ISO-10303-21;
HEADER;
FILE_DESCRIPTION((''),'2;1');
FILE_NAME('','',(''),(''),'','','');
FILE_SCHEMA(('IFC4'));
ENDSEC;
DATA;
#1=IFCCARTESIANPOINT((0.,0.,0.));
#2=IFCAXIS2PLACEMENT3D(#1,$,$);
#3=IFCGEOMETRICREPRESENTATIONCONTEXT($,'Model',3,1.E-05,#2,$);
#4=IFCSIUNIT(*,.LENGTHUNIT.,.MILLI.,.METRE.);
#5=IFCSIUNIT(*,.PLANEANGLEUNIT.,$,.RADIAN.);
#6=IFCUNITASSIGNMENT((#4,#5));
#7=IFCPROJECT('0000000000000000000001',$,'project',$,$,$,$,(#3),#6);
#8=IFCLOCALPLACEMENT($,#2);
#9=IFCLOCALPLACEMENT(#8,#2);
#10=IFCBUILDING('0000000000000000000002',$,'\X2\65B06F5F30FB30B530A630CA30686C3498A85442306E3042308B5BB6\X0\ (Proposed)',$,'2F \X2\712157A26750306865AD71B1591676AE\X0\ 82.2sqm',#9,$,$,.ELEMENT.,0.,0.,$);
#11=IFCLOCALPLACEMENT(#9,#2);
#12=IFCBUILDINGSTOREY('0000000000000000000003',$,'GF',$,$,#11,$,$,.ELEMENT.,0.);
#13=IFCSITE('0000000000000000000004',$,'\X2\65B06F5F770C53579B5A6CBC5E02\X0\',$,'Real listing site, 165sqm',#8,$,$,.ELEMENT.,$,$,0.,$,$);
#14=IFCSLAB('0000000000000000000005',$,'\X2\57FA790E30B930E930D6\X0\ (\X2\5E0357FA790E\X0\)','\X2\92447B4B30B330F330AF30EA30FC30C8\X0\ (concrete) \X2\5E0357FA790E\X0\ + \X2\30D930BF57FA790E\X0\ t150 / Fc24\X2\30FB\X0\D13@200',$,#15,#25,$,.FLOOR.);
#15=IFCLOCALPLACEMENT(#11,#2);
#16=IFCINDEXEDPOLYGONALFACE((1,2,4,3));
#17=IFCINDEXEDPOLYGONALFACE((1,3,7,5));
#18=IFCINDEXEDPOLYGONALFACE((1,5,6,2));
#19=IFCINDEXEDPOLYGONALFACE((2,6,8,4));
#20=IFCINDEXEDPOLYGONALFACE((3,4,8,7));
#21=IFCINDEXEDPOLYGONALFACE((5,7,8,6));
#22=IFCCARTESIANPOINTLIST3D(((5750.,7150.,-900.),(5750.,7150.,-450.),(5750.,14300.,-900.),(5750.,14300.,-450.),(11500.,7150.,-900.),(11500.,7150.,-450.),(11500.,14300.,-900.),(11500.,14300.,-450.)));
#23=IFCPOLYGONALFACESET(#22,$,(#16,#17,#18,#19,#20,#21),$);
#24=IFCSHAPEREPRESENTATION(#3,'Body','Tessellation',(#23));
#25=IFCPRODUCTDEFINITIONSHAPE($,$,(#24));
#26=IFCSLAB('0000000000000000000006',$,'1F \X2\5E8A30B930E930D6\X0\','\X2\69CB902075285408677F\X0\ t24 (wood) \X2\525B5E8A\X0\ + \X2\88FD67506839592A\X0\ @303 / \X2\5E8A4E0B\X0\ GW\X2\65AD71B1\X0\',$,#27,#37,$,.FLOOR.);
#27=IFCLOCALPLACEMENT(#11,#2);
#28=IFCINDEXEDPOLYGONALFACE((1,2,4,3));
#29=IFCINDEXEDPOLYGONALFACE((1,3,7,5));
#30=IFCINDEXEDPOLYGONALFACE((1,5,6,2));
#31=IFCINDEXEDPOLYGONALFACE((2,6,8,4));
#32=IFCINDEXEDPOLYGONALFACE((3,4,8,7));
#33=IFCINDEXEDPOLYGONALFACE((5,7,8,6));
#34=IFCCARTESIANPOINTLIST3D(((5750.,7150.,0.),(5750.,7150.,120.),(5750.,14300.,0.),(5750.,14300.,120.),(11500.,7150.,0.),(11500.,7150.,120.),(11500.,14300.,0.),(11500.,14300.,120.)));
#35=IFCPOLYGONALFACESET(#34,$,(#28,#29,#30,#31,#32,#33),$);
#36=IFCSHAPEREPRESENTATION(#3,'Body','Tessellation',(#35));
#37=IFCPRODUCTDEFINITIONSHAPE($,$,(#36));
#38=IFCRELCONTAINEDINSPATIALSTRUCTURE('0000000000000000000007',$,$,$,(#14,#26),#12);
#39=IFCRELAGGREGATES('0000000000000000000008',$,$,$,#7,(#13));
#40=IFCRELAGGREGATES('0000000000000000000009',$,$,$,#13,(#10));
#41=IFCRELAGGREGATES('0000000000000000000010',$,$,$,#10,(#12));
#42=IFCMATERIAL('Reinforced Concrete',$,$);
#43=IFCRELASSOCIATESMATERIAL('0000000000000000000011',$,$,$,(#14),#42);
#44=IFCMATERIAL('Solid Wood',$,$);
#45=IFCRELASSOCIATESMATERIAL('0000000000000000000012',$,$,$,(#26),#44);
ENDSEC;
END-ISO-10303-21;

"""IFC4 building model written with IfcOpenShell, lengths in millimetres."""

from ifc_helpers import new_model, si_unit, frame, frame_2d, origin, place, context, project, spatial, rectangle, extrude, material, element, save


model = new_model("IFC4")

# Units and contexts
model_context = context("Model", 3, precision=1e-05, world=origin())
ifc_project = project(units=[si_unit("LENGTHUNIT", "METRE", prefix="MILLI"), si_unit("PLANEANGLEUNIT", "RADIAN")], contexts=[model_context])

# Site, building, storey
site_placement = place(None, origin())
site = spatial("IfcSite", under=ifc_project, at=site_placement, Name="新潟県南魚沼市", ObjectType="Real listing site, 165sqm", CompositionType="ELEMENT", RefElevation=0.0)
building_placement = place(site_placement, origin())
building = spatial("IfcBuilding", under=site, at=building_placement, Name="新潟・サウナと水風呂のある家 (Proposed)", ObjectType="2F 無垢材と断熱外皮 82.2sqm", CompositionType="ELEMENT", ElevationOfRefHeight=0.0, ElevationOfTerrain=0.0)
storey_placement = place(building_placement, origin())
storey = spatial("IfcBuildingStorey", under=building, at=storey_placement, Name="GF", CompositionType="ELEMENT", Elevation=0.0)

# Shared definitions
ifc_material_1 = material(Name="Solid Wood")

# Slabs
ifc_material_2 = material(Name="Reinforced Concrete")
slab_1_placement = place(storey_placement, frame((2875.0, 3575.0, -450.0)))
element("IfcSlab", 1, at=slab_1_placement, inside=storey, material=ifc_material_2, Name="基礎スラブ (布基礎)", Description="鉄筋コンクリート (concrete) 布基礎 + ベタ基礎 t150 / Fc24・D13@200", PredefinedType="FLOOR", context=model_context, shape_type="SweptSolid", body=[
    extrude(rectangle(XDim=5750.0, YDim=7150.0, at=frame_2d((2875.0, 3575.0))), frame((2875.0, 3575.0, -450.0)), (0.0, 0.0, 1.0), 450.0),
])
slab_2_placement = place(storey_placement, frame((2875.0, 3575.0, 0.0)))
element("IfcSlab", 2, at=slab_2_placement, inside=storey, material=ifc_material_1, Name="1F 床スラブ", Description="構造用合板 t24 (wood) 剛床 + 製材根太 @303 / 床下 GW断熱", PredefinedType="FLOOR", context=model_context, shape_type="SweptSolid", body=[
    extrude(rectangle(XDim=5750.0, YDim=7150.0, at=frame_2d((2875.0, 3575.0))), frame((2875.0, 3575.0, 0.0)), (0.0, 0.0, 1.0), 120.0),
])

save(model, "model.ifc")
